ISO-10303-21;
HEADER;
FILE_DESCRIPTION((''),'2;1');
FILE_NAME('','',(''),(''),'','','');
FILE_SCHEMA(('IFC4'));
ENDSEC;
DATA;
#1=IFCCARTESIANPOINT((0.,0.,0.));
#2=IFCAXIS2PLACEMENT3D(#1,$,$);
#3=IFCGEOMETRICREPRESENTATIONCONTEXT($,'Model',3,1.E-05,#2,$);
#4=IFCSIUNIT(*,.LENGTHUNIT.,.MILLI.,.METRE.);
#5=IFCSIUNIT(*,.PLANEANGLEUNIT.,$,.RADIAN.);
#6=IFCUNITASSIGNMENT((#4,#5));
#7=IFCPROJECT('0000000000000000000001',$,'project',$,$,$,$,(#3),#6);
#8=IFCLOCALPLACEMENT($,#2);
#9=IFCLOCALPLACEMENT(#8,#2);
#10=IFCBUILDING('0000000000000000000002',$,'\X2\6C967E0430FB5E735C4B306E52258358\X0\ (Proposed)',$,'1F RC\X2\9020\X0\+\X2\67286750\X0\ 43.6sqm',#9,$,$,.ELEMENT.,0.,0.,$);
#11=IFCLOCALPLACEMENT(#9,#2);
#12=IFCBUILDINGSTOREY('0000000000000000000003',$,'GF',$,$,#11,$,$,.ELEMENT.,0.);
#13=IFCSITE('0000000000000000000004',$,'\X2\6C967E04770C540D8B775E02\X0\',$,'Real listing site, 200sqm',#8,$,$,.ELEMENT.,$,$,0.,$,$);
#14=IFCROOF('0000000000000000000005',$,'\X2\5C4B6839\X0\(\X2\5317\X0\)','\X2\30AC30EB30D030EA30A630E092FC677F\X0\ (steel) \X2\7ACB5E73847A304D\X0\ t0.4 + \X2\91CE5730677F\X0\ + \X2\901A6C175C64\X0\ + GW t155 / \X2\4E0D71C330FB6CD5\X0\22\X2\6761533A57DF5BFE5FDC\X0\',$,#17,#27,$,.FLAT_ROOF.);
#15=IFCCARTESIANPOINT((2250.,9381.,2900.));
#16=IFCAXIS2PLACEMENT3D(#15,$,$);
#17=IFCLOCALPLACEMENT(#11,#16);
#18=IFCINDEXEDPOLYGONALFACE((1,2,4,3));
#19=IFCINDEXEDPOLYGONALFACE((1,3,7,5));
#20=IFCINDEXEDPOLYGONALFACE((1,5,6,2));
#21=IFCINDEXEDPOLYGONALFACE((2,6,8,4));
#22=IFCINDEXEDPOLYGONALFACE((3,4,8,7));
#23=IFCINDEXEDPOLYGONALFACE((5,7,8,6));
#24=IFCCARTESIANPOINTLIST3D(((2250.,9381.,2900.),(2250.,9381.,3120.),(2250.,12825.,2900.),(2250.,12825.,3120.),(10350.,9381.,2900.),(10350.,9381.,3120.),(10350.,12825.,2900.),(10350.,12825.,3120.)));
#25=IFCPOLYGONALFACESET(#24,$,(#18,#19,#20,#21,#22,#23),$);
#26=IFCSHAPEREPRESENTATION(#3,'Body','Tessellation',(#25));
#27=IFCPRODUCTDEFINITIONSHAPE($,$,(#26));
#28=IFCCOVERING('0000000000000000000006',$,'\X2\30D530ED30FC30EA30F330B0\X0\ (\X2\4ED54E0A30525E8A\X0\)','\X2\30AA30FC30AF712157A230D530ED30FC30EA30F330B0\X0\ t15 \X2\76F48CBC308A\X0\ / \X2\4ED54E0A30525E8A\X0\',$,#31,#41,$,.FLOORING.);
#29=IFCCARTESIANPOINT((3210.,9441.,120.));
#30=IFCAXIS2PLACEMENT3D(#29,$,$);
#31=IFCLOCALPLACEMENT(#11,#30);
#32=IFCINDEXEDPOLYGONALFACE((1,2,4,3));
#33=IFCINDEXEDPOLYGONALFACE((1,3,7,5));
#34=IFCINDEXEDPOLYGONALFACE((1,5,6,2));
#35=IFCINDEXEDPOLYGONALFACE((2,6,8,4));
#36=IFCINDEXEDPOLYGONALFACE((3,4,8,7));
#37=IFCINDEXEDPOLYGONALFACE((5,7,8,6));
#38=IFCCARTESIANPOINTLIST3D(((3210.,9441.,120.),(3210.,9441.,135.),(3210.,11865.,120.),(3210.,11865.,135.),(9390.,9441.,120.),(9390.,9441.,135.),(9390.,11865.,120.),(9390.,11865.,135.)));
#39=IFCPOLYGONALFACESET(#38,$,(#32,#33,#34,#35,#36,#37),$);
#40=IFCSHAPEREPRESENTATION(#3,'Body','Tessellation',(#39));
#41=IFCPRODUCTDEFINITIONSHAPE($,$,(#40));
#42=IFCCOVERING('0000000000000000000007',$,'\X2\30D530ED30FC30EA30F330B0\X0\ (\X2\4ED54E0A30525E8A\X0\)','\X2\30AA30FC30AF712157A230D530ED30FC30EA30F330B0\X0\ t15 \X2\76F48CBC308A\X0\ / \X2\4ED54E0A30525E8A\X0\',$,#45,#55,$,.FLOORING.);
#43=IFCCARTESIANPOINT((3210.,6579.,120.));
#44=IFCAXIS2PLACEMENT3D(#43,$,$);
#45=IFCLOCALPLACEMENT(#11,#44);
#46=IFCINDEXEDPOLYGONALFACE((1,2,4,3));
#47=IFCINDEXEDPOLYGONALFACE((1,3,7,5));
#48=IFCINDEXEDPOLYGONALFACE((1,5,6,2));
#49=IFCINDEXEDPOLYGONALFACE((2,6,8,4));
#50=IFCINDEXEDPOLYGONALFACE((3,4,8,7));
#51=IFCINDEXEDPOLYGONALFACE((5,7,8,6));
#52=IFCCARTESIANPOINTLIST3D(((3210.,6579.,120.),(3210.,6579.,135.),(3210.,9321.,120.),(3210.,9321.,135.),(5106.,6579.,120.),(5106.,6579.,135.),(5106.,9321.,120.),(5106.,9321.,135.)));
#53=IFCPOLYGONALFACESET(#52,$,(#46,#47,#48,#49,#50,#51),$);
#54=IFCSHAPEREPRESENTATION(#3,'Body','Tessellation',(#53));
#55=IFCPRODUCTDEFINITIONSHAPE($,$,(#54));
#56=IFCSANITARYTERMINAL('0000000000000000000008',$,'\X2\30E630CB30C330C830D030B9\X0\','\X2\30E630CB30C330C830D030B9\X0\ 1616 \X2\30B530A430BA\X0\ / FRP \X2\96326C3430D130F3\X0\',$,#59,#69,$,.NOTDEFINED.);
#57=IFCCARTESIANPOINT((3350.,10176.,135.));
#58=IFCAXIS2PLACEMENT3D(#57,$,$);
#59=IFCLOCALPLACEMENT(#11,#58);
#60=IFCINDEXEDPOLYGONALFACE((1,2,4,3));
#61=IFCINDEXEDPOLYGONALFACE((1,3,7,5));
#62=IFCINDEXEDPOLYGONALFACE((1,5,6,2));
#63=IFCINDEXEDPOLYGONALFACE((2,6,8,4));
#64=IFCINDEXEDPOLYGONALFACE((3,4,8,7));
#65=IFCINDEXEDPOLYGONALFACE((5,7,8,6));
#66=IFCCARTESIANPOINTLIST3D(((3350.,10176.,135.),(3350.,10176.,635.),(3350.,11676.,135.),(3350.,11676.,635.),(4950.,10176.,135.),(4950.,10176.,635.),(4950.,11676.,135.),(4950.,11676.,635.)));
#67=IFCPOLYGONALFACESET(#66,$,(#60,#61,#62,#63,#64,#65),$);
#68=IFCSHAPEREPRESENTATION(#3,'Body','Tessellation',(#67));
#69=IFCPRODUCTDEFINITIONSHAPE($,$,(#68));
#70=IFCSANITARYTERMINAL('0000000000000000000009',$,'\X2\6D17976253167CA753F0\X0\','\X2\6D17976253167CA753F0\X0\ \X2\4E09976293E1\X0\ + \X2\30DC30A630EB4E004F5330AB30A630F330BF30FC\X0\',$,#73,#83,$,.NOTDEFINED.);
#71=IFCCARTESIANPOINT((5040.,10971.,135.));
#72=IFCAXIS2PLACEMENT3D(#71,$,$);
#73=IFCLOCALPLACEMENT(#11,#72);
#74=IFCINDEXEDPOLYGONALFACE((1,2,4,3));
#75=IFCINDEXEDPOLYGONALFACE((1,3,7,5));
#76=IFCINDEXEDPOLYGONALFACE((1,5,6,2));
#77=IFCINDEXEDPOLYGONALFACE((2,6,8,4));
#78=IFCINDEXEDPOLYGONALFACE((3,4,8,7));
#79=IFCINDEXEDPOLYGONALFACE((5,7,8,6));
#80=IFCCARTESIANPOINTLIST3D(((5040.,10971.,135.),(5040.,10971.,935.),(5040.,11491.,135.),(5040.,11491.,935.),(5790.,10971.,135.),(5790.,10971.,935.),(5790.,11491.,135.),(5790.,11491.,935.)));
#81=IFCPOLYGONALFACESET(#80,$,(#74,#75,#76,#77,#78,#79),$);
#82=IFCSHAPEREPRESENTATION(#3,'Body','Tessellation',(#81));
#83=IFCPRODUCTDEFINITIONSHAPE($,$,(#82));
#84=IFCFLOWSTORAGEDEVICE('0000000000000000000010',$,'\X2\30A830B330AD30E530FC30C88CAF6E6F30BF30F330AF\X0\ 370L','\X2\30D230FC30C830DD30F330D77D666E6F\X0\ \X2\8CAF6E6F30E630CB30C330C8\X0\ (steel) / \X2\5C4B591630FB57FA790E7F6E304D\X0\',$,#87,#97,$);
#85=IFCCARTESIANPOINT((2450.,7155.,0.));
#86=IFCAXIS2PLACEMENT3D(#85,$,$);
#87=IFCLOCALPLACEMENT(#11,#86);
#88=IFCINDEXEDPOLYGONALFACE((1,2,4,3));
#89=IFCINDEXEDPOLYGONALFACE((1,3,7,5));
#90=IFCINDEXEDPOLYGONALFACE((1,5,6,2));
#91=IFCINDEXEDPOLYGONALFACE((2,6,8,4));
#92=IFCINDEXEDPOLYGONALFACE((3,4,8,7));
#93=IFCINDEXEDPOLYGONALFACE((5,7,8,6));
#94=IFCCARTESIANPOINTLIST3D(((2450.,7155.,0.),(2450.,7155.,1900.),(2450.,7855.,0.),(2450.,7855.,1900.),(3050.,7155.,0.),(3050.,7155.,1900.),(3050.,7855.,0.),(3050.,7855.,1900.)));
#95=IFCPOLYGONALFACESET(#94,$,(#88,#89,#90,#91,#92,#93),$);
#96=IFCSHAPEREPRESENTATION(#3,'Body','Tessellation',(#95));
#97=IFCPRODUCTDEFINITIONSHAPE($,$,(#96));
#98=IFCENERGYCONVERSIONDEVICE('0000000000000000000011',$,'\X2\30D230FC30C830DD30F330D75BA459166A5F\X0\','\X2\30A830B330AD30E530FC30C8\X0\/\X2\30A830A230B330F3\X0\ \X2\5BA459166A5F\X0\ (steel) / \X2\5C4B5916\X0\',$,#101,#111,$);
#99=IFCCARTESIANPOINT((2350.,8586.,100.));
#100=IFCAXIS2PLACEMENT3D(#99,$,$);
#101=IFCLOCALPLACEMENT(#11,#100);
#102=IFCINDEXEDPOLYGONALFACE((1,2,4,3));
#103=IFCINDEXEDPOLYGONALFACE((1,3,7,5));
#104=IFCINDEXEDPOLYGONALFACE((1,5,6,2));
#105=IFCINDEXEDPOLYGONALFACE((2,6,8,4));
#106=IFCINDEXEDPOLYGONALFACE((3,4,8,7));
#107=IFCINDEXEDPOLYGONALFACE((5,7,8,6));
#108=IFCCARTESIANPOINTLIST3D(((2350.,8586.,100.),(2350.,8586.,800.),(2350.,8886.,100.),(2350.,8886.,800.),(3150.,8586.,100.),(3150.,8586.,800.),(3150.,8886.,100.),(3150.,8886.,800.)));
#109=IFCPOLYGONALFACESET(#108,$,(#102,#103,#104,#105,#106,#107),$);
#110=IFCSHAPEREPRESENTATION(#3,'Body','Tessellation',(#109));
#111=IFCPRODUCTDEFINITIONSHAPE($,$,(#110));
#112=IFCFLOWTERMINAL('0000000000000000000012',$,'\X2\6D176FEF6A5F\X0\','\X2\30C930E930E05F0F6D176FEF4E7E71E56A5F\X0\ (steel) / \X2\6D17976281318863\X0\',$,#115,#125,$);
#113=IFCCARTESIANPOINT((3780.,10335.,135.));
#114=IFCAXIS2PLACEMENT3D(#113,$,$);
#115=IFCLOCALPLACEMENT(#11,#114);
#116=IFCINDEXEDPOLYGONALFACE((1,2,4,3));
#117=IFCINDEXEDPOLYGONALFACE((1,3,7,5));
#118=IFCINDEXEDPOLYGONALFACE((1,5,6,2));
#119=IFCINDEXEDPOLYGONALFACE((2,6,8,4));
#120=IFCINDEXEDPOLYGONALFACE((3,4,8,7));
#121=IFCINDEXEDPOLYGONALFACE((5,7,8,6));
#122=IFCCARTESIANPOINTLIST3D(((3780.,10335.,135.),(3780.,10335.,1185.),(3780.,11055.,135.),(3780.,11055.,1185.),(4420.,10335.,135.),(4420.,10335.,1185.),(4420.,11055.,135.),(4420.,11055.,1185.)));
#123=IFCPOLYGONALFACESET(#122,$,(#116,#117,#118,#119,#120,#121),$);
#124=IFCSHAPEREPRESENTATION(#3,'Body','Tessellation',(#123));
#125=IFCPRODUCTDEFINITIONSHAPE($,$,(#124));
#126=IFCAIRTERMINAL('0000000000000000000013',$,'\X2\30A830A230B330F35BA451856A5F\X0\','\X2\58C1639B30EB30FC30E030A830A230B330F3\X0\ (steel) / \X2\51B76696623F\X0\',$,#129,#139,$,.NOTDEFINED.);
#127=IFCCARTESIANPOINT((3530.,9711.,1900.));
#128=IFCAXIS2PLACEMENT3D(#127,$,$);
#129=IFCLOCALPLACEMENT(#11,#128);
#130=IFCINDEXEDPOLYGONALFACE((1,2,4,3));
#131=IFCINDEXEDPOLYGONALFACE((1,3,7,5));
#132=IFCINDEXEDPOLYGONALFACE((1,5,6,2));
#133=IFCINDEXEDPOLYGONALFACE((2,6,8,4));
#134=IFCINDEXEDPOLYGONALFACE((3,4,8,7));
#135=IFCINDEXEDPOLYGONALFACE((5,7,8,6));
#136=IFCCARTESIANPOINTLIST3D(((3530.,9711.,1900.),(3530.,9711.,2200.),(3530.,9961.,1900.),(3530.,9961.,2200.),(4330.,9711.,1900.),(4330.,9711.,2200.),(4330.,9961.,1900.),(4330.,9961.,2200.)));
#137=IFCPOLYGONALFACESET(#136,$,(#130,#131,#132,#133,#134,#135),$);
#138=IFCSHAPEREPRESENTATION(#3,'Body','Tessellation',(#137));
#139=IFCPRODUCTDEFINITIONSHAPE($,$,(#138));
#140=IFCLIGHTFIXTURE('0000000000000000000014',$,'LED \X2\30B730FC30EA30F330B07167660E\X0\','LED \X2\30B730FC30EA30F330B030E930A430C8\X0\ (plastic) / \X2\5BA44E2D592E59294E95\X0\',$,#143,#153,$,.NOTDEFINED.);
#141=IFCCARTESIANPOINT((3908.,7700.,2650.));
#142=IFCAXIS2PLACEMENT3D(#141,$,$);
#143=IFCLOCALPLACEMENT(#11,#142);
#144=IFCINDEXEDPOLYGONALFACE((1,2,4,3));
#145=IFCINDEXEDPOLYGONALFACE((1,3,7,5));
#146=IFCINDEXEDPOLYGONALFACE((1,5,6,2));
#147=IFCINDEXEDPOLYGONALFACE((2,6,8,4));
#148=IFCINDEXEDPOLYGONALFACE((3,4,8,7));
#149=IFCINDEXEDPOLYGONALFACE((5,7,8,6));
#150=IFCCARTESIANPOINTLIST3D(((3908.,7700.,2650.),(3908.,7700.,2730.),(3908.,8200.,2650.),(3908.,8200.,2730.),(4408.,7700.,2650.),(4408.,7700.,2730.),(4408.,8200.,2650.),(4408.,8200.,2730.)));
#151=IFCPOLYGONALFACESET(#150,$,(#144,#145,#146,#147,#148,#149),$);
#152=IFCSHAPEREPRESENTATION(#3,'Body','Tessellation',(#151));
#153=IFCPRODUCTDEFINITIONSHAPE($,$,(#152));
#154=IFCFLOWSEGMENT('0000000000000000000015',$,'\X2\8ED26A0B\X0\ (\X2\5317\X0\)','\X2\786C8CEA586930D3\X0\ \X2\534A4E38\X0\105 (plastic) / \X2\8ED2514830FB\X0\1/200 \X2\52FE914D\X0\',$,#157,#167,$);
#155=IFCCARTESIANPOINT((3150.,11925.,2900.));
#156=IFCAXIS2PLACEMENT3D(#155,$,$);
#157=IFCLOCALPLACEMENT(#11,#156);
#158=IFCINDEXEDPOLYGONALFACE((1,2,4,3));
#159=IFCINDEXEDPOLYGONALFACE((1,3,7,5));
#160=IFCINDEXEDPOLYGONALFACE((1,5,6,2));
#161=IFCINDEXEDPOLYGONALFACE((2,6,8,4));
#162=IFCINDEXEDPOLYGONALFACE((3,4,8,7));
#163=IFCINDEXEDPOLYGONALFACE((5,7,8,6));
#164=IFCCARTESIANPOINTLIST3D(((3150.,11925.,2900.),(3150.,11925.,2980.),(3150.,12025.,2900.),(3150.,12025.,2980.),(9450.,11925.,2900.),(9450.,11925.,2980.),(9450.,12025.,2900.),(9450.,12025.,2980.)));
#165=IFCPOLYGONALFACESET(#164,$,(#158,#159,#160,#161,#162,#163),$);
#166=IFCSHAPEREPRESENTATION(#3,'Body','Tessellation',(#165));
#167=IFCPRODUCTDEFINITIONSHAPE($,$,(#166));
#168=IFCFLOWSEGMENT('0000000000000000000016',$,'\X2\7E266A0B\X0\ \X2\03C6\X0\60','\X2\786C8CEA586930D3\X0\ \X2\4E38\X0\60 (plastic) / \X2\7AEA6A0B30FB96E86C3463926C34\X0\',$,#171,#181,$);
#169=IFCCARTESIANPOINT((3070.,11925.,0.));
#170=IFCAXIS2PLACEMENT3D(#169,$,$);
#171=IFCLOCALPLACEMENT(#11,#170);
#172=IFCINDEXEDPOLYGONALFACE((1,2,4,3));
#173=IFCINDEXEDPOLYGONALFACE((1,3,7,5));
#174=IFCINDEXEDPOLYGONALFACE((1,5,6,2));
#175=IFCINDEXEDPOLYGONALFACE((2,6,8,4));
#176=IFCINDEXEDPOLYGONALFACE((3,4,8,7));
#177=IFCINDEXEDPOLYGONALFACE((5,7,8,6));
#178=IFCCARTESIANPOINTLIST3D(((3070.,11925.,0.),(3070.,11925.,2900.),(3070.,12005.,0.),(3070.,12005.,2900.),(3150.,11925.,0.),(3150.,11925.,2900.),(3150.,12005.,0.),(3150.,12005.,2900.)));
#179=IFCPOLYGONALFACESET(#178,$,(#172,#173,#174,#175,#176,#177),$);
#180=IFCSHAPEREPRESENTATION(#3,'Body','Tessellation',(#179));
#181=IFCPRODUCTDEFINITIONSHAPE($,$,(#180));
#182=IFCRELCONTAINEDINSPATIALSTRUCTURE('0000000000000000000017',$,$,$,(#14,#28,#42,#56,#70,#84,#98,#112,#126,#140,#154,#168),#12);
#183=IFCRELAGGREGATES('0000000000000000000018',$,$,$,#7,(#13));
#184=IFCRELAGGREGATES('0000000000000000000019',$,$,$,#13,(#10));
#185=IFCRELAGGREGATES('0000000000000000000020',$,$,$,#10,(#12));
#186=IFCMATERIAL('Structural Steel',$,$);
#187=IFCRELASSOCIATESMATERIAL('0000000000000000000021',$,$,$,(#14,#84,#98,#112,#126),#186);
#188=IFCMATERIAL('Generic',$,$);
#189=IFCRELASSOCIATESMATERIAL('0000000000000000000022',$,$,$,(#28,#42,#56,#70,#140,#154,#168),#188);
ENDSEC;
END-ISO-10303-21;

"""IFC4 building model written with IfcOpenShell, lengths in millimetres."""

from ifc_helpers import new_model, si_unit, frame, frame_2d, origin, place, context, project, spatial, rectangle, extrude, material, element, save


model = new_model("IFC4")

# Units and contexts
model_context = context("Model", 3, precision=1e-05, world=origin())
ifc_project = project(units=[si_unit("LENGTHUNIT", "METRE", prefix="MILLI"), si_unit("PLANEANGLEUNIT", "RADIAN")], contexts=[model_context])

# Site, building, storey
site_placement = place(None, origin())
site = spatial("IfcSite", under=ifc_project, at=site_placement, Name="沖縄県名護市", ObjectType="Real listing site, 200sqm", CompositionType="ELEMENT", RefElevation=0.0)
building_placement = place(site_placement, origin())
building = spatial("IfcBuilding", under=site, at=building_placement, Name="沖縄・平屋の別荘 (Proposed)", ObjectType="1F RC造+木材 43.6sqm", CompositionType="ELEMENT", ElevationOfRefHeight=0.0, ElevationOfTerrain=0.0)
storey_placement = place(building_placement, origin())
storey = spatial("IfcBuildingStorey", under=building, at=storey_placement, Name="GF", CompositionType="ELEMENT", Elevation=0.0)

# Roof
ifc_material_1 = material(Name="Structural Steel")
roof_placement = place(storey_placement, frame((2250.0, 9381.0, 2900.0)))
element("IfcRoof", 1, at=roof_placement, inside=storey, material=ifc_material_1, Name="屋根(北)", Description="ガルバリウム鋼板 (steel) 立平葺き t0.4 + 野地板 + 通気層 + GW t155 / 不燃・法22条区域対応", PredefinedType="FLAT_ROOF", context=model_context, shape_type="SweptSolid", body=[
    extrude(rectangle(XDim=8100.0, YDim=3444.0, at=frame_2d((4050.0, 1722.0))), frame((2250.0, 9381.0, 2900.0)), (0.0, 0.0, 1.0), 220.0),
])

# Coverings
ifc_material_2 = material(Name="Generic")
covering_1_placement = place(storey_placement, frame((3210.0, 9441.0, 120.0)))
element("IfcCovering", 2, at=covering_1_placement, inside=storey, material=ifc_material_2, Name="フローリング (仕上げ床)", Description="オーク無垢フローリング t15 直貼り / 仕上げ床", PredefinedType="FLOORING", context=model_context, shape_type="SweptSolid", body=[
    extrude(rectangle(XDim=6180.0, YDim=2424.0, at=frame_2d((3090.0, 1212.0))), frame((3210.0, 9441.0, 120.0)), (0.0, 0.0, 1.0), 15.0),
])
covering_2_placement = place(storey_placement, frame((3210.0, 6579.0, 120.0)))
element("IfcCovering", 3, at=covering_2_placement, inside=storey, material=ifc_material_2, Name="フローリング (仕上げ床)", Description="オーク無垢フローリング t15 直貼り / 仕上げ床", PredefinedType="FLOORING", context=model_context, shape_type="SweptSolid", body=[
    extrude(rectangle(XDim=1896.0, YDim=2742.0, at=frame_2d((948.0, 1371.0))), frame((3210.0, 6579.0, 120.0)), (0.0, 0.0, 1.0), 15.0),
])

# Sanitary terminals
sanitary_terminal_1_placement = place(storey_placement, frame((3350.0, 10176.0, 135.0)))
element("IfcSanitaryTerminal", 4, at=sanitary_terminal_1_placement, inside=storey, material=ifc_material_2, Name="ユニットバス", Description="ユニットバス 1616 サイズ / FRP 防水パン", PredefinedType="NOTDEFINED", context=model_context, shape_type="SweptSolid", body=[
    extrude(rectangle(XDim=1600.0, YDim=1500.0, at=frame_2d((800.0, 750.0))), frame((3350.0, 10176.0, 135.0)), (0.0, 0.0, 1.0), 500.0),
])
sanitary_terminal_2_placement = place(storey_placement, frame((5040.0, 10971.0, 135.0)))
element("IfcSanitaryTerminal", 5, at=sanitary_terminal_2_placement, inside=storey, material=ifc_material_2, Name="洗面化粧台", Description="洗面化粧台 三面鏡 + ボウル一体カウンター", PredefinedType="NOTDEFINED", context=model_context, shape_type="SweptSolid", body=[
    extrude(rectangle(XDim=750.0, YDim=520.0, at=frame_2d((375.0, 260.0))), frame((5040.0, 10971.0, 135.0)), (0.0, 0.0, 1.0), 800.0),
])

# Flow storage device
flow_storage_device_placement = place(storey_placement, frame((2450.0, 7155.0, 0.0)))
element("IfcFlowStorageDevice", 6, at=flow_storage_device_placement, inside=storey, material=ifc_material_1, Name="エコキュート貯湯タンク 370L", Description="ヒートポンプ給湯 貯湯ユニット (steel) / 屋外・基礎置き", context=model_context, shape_type="SweptSolid", body=[
    extrude(rectangle(XDim=600.0, YDim=700.0, at=frame_2d((300.0, 350.0))), frame((2450.0, 7155.0, 0.0)), (0.0, 0.0, 1.0), 1900.0),
])

# Energy conversion device
energy_conversion_device_placement = place(storey_placement, frame((2350.0, 8586.0, 100.0)))
element("IfcEnergyConversionDevice", 7, at=energy_conversion_device_placement, inside=storey, material=ifc_material_1, Name="ヒートポンプ室外機", Description="エコキュート/エアコン 室外機 (steel) / 屋外", context=model_context, shape_type="SweptSolid", body=[
    extrude(rectangle(XDim=800.0, YDim=300.0, at=frame_2d((400.0, 150.0))), frame((2350.0, 8586.0, 100.0)), (0.0, 0.0, 1.0), 700.0),
])

# Flow terminal
flow_terminal_placement = place(storey_placement, frame((3780.0, 10335.0, 135.0)))
element("IfcFlowTerminal", 8, at=flow_terminal_placement, inside=storey, material=ifc_material_1, Name="洗濯機", Description="ドラム式洗濯乾燥機 (steel) / 洗面脱衣", context=model_context, shape_type="SweptSolid", body=[
    extrude(rectangle(XDim=640.0, YDim=720.0, at=frame_2d((320.0, 360.0))), frame((3780.0, 10335.0, 135.0)), (0.0, 0.0, 1.0), 1050.0),
])

# Air terminal
air_terminal_placement = place(storey_placement, frame((3530.0, 9711.0, 1900.0)))
element("IfcAirTerminal", 9, at=air_terminal_placement, inside=storey, material=ifc_material_1, Name="エアコン室内機", Description="壁掛ルームエアコン (steel) / 冷暖房", PredefinedType="NOTDEFINED", context=model_context, shape_type="SweptSolid", body=[
    extrude(rectangle(XDim=800.0, YDim=250.0, at=frame_2d((400.0, 125.0))), frame((3530.0, 9711.0, 1900.0)), (0.0, 0.0, 1.0), 300.0),
])

# Light fixture
light_fixture_placement = place(storey_placement, frame((3908.0, 7700.0, 2650.0)))
element("IfcLightFixture", 10, at=light_fixture_placement, inside=storey, material=ifc_material_2, Name="LED シーリング照明", Description="LED シーリングライト (plastic) / 室中央天井", PredefinedType="NOTDEFINED", context=model_context, shape_type="SweptSolid", body=[
    extrude(rectangle(XDim=500.0, YDim=500.0, at=frame_2d((250.0, 250.0))), frame((3908.0, 7700.0, 2650.0)), (0.0, 0.0, 1.0), 80.0),
])

# Flow segments
flow_segment_1_placement = place(storey_placement, frame((3150.0, 11925.0, 2900.0)))
element("IfcFlowSegment", 11, at=flow_segment_1_placement, inside=storey, material=ifc_material_2, Name="軒樋 (北)", Description="硬質塩ビ 半丸105 (plastic) / 軒先・1/200 勾配", context=model_context, shape_type="SweptSolid", body=[
    extrude(rectangle(XDim=6300.0, YDim=100.0, at=frame_2d((3150.0, 50.0))), frame((3150.0, 11925.0, 2900.0)), (0.0, 0.0, 1.0), 80.0),
])
flow_segment_2_placement = place(storey_placement, frame((3070.0, 11925.0, 0.0)))
element("IfcFlowSegment", 12, at=flow_segment_2_placement, inside=storey, material=ifc_material_2, Name="縦樋 φ60", Description="硬質塩ビ 丸60 (plastic) / 竪樋・雨水排水", context=model_context, shape_type="SweptSolid", body=[
    extrude(rectangle(XDim=80.0, YDim=80.0, at=frame_2d((40.0, 40.0))), frame((3070.0, 11925.0, 0.0)), (0.0, 0.0, 1.0), 2900.0),
])

save(model, "model.ifc")
